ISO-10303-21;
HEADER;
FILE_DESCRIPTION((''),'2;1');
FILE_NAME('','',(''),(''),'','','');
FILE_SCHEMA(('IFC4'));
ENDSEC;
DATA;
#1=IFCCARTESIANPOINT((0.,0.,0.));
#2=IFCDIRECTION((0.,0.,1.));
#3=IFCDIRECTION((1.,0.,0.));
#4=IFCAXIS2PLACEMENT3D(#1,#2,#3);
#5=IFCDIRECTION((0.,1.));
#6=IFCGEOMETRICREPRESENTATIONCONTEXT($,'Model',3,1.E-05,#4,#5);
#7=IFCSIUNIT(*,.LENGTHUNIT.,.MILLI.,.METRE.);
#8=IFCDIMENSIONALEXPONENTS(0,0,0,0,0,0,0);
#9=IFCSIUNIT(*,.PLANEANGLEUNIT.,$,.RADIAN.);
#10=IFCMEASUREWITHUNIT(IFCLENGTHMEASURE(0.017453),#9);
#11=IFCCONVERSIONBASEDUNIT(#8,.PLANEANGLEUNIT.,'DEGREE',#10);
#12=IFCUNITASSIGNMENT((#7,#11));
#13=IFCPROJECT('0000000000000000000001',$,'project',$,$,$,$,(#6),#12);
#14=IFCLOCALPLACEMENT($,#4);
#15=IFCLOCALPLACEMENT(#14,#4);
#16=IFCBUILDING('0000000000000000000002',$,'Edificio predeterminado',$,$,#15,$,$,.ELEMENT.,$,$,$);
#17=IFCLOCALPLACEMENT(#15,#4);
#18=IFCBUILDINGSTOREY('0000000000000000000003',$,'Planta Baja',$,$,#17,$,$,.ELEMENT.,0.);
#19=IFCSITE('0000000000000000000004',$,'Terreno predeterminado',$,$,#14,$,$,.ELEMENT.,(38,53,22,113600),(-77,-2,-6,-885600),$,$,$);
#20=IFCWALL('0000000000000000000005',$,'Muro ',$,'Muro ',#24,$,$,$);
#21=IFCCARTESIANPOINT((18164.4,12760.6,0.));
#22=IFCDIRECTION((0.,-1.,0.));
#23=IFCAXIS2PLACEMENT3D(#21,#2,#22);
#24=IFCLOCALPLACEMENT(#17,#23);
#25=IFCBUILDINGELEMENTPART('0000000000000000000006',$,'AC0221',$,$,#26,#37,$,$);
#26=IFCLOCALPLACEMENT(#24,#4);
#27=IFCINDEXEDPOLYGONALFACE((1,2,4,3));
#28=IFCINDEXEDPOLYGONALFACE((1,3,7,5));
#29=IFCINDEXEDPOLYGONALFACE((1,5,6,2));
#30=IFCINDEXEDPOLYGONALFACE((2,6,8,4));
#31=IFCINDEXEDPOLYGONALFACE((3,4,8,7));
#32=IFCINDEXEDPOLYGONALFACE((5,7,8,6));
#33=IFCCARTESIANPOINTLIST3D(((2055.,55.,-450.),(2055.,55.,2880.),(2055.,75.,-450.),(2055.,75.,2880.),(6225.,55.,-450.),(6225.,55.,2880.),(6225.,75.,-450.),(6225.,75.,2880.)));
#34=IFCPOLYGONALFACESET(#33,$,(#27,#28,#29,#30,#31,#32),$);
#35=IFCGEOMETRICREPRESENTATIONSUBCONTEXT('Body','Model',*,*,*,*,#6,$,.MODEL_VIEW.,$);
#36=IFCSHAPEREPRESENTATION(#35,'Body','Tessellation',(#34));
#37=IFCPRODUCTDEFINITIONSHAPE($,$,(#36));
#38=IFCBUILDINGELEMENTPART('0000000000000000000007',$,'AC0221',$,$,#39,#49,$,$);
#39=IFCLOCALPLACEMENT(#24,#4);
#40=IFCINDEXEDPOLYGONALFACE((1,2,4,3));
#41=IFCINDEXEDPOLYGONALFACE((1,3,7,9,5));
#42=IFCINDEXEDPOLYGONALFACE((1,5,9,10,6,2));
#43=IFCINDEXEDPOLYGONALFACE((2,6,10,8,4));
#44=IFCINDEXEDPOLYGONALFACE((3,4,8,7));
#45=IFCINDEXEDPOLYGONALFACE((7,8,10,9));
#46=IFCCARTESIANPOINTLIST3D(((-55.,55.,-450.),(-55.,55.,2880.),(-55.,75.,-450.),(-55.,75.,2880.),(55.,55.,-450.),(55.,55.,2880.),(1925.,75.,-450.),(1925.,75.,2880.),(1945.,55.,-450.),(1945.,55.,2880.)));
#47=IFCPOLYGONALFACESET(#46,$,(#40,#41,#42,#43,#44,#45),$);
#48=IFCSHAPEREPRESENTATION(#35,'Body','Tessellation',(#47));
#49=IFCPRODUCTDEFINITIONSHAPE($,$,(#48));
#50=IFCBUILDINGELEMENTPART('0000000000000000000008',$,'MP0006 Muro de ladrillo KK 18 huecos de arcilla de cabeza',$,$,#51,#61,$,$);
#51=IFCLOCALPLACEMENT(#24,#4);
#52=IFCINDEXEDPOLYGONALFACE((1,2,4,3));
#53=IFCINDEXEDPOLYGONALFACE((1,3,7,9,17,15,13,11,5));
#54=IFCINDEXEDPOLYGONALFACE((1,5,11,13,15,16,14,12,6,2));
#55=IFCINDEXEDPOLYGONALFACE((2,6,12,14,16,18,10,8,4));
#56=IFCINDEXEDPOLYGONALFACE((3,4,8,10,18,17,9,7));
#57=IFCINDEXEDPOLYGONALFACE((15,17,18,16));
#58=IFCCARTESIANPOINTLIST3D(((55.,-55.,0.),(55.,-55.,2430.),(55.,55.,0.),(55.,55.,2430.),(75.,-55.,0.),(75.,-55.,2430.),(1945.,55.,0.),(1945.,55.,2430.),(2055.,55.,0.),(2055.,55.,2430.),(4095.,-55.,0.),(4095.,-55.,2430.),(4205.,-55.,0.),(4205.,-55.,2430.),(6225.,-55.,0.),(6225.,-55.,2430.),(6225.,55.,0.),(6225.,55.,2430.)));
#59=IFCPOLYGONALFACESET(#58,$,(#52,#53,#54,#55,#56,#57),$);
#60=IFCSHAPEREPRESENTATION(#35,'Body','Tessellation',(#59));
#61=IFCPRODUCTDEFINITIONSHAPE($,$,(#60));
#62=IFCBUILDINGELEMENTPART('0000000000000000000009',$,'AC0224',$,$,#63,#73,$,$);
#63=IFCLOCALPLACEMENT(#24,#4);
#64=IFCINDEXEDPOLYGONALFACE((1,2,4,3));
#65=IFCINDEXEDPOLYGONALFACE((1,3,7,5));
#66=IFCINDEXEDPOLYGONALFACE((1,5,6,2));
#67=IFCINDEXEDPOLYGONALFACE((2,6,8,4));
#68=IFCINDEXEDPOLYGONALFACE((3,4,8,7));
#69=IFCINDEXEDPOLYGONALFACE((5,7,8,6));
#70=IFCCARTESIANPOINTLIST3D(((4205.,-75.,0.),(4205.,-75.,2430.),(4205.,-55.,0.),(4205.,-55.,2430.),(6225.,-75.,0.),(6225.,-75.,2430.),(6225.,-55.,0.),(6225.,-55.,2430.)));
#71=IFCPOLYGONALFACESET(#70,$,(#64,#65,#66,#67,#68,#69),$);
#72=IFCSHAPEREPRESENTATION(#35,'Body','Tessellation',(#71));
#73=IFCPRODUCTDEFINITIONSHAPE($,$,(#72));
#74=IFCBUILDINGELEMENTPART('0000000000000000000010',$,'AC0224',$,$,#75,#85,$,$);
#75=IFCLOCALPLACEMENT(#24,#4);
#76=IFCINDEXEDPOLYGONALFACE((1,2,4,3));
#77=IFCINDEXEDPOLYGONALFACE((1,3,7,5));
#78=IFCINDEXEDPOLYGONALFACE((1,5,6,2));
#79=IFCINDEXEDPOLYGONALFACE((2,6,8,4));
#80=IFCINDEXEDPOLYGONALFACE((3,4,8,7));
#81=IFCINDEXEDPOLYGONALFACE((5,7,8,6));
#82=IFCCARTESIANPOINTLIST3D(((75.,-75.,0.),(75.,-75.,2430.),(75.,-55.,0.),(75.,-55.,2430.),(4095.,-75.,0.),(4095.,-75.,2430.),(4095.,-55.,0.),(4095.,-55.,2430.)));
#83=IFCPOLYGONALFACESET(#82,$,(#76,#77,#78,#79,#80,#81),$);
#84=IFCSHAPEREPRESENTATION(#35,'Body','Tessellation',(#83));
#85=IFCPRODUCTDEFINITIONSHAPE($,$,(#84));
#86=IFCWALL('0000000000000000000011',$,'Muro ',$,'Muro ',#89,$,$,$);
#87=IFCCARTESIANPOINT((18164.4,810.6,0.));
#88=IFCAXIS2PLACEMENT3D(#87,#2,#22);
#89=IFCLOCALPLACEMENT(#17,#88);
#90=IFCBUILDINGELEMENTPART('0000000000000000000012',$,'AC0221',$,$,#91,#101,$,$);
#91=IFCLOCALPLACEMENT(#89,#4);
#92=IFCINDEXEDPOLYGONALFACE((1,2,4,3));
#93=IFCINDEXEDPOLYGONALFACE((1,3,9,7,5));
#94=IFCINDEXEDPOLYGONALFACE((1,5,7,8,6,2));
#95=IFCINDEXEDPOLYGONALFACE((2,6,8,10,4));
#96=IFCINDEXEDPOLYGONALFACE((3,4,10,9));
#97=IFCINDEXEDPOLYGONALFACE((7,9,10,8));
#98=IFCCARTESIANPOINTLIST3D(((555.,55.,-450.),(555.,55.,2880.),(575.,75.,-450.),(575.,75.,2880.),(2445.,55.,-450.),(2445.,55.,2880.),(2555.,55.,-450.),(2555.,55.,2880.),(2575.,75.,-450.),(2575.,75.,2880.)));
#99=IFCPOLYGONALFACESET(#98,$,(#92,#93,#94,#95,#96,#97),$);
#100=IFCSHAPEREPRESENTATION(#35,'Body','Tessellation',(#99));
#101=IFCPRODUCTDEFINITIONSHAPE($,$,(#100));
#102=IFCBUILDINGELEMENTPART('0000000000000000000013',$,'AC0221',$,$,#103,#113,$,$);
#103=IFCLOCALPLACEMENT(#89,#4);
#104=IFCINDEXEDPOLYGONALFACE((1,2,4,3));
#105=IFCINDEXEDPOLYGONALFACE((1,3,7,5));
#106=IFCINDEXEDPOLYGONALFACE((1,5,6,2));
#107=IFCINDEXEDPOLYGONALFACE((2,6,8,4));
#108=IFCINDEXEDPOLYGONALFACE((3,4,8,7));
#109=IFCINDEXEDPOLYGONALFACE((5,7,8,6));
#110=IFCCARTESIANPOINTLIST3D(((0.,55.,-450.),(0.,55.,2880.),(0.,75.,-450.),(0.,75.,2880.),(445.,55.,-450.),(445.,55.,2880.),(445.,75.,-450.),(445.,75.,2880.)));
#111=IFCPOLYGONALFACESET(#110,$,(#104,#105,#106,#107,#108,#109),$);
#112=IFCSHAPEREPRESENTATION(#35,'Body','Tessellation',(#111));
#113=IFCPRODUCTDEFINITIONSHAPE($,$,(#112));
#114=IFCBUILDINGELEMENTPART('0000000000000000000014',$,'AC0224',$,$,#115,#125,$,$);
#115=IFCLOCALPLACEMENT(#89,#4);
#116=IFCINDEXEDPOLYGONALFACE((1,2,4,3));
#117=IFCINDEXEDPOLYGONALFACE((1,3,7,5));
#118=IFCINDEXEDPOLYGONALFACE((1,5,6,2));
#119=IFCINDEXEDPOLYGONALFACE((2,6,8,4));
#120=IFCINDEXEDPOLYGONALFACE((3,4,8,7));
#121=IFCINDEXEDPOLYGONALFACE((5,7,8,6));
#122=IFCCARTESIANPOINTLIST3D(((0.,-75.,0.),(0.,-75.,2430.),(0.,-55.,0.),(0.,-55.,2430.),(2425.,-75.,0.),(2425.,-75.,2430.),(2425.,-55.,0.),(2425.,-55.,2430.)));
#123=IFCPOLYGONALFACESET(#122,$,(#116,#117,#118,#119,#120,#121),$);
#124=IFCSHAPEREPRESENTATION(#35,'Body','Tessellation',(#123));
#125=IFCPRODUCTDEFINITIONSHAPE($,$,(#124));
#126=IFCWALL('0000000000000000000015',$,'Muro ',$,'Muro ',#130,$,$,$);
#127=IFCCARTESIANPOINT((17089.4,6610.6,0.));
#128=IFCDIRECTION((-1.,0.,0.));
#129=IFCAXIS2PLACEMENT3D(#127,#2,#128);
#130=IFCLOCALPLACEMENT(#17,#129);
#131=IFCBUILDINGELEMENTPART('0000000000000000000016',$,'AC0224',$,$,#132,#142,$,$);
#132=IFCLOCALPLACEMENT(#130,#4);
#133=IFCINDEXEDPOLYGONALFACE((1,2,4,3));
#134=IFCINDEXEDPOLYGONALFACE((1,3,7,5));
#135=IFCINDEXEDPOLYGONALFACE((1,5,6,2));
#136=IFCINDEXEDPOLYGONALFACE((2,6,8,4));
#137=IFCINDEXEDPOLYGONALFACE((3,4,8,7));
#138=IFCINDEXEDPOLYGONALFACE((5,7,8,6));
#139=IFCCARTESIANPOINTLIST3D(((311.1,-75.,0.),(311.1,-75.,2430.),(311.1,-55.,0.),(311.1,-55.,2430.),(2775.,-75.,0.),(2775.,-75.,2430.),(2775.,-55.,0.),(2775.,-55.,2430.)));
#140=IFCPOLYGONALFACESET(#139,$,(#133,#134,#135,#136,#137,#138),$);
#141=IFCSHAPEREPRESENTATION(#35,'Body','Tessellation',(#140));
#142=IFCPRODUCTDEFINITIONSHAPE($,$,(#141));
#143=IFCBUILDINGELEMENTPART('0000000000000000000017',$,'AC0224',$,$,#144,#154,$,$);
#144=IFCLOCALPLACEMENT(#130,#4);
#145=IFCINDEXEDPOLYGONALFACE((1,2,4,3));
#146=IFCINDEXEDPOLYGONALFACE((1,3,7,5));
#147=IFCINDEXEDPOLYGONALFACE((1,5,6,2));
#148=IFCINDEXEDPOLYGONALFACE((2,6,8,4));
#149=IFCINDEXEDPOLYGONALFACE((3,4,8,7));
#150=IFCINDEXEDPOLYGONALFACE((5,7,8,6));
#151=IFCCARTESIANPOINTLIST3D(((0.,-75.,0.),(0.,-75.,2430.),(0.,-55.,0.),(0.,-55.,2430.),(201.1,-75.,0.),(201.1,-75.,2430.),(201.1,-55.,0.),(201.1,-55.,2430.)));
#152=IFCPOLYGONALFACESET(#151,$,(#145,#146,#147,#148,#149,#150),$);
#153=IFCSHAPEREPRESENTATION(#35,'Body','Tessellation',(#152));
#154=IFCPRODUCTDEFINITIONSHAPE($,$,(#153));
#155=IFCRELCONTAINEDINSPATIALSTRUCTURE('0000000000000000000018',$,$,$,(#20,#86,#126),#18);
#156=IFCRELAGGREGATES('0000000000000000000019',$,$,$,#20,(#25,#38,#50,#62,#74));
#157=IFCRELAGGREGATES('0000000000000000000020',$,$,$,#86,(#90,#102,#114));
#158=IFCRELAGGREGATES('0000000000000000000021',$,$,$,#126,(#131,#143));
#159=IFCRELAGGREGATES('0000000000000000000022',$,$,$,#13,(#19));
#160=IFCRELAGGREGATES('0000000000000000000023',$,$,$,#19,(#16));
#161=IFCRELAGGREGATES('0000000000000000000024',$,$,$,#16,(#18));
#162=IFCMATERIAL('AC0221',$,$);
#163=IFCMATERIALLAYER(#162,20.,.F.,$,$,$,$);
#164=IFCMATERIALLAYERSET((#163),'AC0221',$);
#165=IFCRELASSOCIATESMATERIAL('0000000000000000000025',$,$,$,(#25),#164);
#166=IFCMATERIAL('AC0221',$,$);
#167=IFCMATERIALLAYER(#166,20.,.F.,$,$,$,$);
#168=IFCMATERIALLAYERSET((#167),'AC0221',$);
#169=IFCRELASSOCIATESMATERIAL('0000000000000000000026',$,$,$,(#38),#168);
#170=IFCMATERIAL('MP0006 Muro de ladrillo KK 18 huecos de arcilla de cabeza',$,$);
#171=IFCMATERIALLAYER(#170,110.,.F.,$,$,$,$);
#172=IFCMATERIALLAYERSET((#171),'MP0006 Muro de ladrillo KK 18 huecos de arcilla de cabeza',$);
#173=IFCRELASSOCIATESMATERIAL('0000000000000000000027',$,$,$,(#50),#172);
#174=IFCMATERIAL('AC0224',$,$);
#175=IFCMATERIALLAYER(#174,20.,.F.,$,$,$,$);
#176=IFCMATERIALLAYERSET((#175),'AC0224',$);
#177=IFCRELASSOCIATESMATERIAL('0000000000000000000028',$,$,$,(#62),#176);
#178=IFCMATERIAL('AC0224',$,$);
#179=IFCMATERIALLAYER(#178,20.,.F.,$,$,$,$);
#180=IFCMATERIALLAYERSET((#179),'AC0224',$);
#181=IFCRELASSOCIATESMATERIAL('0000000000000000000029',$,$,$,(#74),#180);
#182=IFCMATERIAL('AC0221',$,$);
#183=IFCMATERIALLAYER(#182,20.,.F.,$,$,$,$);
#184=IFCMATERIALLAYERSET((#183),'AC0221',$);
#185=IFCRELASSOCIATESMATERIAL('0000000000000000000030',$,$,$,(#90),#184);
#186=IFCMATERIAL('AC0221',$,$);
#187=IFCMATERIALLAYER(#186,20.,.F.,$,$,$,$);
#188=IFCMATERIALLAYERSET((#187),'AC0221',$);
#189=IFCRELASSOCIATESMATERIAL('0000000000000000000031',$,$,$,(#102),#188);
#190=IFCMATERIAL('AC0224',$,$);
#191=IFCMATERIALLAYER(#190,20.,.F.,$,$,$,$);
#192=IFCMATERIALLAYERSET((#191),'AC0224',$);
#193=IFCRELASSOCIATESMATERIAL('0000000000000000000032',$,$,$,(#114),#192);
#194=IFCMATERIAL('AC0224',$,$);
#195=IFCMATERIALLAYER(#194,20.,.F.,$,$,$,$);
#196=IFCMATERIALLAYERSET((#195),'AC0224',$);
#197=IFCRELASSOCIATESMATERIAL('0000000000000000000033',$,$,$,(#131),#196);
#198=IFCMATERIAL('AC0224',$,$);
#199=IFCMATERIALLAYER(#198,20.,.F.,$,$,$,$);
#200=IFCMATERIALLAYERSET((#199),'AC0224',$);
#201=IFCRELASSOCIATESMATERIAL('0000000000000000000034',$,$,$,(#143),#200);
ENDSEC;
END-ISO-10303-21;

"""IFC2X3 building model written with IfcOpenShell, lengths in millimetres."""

from ifc_helpers import new_model, entity, si_unit, converted_unit, direction, frame, origin_with_axes, place, context, subcontext, project, spatial, polyline, outline, extrude, material, layer, layer_set, layer_usage, element, aggregate, save


model = new_model("IFC2X3")

# Units and contexts
model_context = context("Model", 3, precision=1e-05, world=origin_with_axes(), true_north=direction((0.0, 1.0)))
body_context = subcontext(model_context, "Body", "Model", "MODEL_VIEW")
ifc_project = project(units=[si_unit("LENGTHUNIT", "METRE", prefix="MILLI"), converted_unit("PLANEANGLEUNIT", "DEGREE", entity("IfcLengthMeasure", 0.017453), si_unit("PLANEANGLEUNIT", "RADIAN"), dimensions=[0, 0, 0, 0, 0, 0, 0])], contexts=[model_context])

# Site, building, storey
site_placement = place(None, origin_with_axes())
site = spatial("IfcSite", under=ifc_project, at=site_placement, Name="Terreno predeterminado", CompositionType="ELEMENT", RefLatitude=(38, 53, 22, 113600), RefLongitude=(-77, -2, -6, -885600))
building_placement = place(site_placement, origin_with_axes())
building = spatial("IfcBuilding", under=site, at=building_placement, Name="Edificio predeterminado", CompositionType="ELEMENT")
storey_placement = place(building_placement, origin_with_axes())
storey = spatial("IfcBuildingStorey", under=building, at=storey_placement, Name="Planta Baja", CompositionType="ELEMENT", Elevation=0.0)

# Walls, building element parts
wall_1_placement = place(storey_placement, frame((18164.4, 12760.6, 0.0), z_axis=(0.0, 0.0, 1.0), x_axis=(0.0, -1.0, 0.0)))
wall_1 = element("IfcWall", 1, at=wall_1_placement, inside=storey, Name="Muro ", ObjectType="Muro ")
ifc_material_1 = material(Name="AC0221")
ifc_layer_1 = layer(ifc_material_1, 20.0, ventilated=False)
ifc_layer_set_1 = layer_set([ifc_layer_1], Name="AC0221")
ifc_layer_usage_1 = layer_usage(ifc_layer_set_1, "AXIS2", "NEGATIVE", -75.0)
building_element_part_1_placement = place(wall_1_placement, origin_with_axes())
building_element_part_1 = element("IfcBuildingElementPart", 2, at=building_element_part_1_placement, material=ifc_layer_usage_1, Name="AC0221", context=body_context, shape_type="SweptSolid", body=[
    extrude(outline(polyline([(6225.0, 75.0), (6225.0, 55.0), (2055.0, 55.0), (2055.0, 75.0), (6225.0, 75.0)])), frame((0.0, 0.0, -450.0), z_axis=(0.0, 0.0, 1.0), x_axis=(1.0, 0.0, 0.0)), (0.0, 0.0, 1.0), 3330.0),
])
ifc_material_2 = material(Name="AC0221")
ifc_layer_2 = layer(ifc_material_2, 20.0, ventilated=False)
ifc_layer_set_2 = layer_set([ifc_layer_2], Name="AC0221")
ifc_layer_usage_2 = layer_usage(ifc_layer_set_2, "AXIS2", "NEGATIVE", -75.0)
building_element_part_2_placement = place(wall_1_placement, origin_with_axes())
building_element_part_2 = element("IfcBuildingElementPart", 3, at=building_element_part_2_placement, material=ifc_layer_usage_2, Name="AC0221", context=body_context, shape_type="SweptSolid", body=[
    extrude(outline(polyline([(1925.0, 75.0), (1945.0, 55.0), (55.0, 55.0), (-55.0, 55.0), (-55.0, 75.0), (1925.0, 75.0)])), frame((0.0, 0.0, -450.0), z_axis=(0.0, 0.0, 1.0), x_axis=(1.0, 0.0, 0.0)), (0.0, 0.0, 1.0), 3330.0),
])
ifc_material_3 = material(Name="MP0006 Muro de ladrillo KK 18 huecos de arcilla de cabeza")
ifc_layer_3 = layer(ifc_material_3, 110.0, ventilated=False)
ifc_layer_set_3 = layer_set([ifc_layer_3], Name="MP0006 Muro de ladrillo KK 18 huecos de arcilla de cabeza")
ifc_layer_usage_3 = layer_usage(ifc_layer_set_3, "AXIS2", "NEGATIVE", -55.0)
building_element_part_3_placement = place(wall_1_placement, origin_with_axes())
building_element_part_3 = element("IfcBuildingElementPart", 4, at=building_element_part_3_placement, material=ifc_layer_usage_3, Name="MP0006 Muro de ladrillo KK 18 huecos de arcilla de cabeza", context=body_context, shape_type="SweptSolid", body=[
    extrude(outline(polyline([(6225.0, 55.0), (6225.0, -55.0), (4205.0, -55.0), (4095.0, -55.0), (75.0, -55.0), (55.0, -55.0), (55.0, 55.0), (1945.0, 55.0), (2055.0, 55.0), (6225.0, 55.0)])), origin_with_axes(), (0.0, 0.0, 1.0), 2430.0),
])
ifc_material_4 = material(Name="AC0224")
ifc_layer_4 = layer(ifc_material_4, 20.0, ventilated=False)
ifc_layer_set_4 = layer_set([ifc_layer_4], Name="AC0224")
ifc_layer_usage_4 = layer_usage(ifc_layer_set_4, "AXIS2", "NEGATIVE", 55.0)
building_element_part_4_placement = place(wall_1_placement, origin_with_axes())
building_element_part_4 = element("IfcBuildingElementPart", 5, at=building_element_part_4_placement, material=ifc_layer_usage_4, Name="AC0224", context=body_context, shape_type="SweptSolid", body=[
    extrude(outline(polyline([(6225.0, -55.0), (6225.0, -75.0), (4205.0, -75.0), (4205.0, -55.0), (6225.0, -55.0)])), origin_with_axes(), (0.0, 0.0, 1.0), 2430.0),
])
ifc_material_5 = material(Name="AC0224")
ifc_layer_5 = layer(ifc_material_5, 20.0, ventilated=False)
ifc_layer_set_5 = layer_set([ifc_layer_5], Name="AC0224")
ifc_layer_usage_5 = layer_usage(ifc_layer_set_5, "AXIS2", "NEGATIVE", 55.0)
building_element_part_5_placement = place(wall_1_placement, origin_with_axes())
building_element_part_5 = element("IfcBuildingElementPart", 6, at=building_element_part_5_placement, material=ifc_layer_usage_5, Name="AC0224", context=body_context, shape_type="SweptSolid", body=[
    extrude(outline(polyline([(4095.0, -55.0), (4095.0, -75.0), (75.0, -75.0), (75.0, -55.0), (4095.0, -55.0)])), origin_with_axes(), (0.0, 0.0, 1.0), 2430.0),
])
aggregate(wall_1, [building_element_part_1, building_element_part_2, building_element_part_3, building_element_part_4, building_element_part_5])
wall_2_placement = place(storey_placement, frame((18164.4, 810.6, 0.0), z_axis=(0.0, 0.0, 1.0), x_axis=(0.0, -1.0, 0.0)))
wall_2 = element("IfcWall", 7, at=wall_2_placement, inside=storey, Name="Muro ", ObjectType="Muro ")
ifc_material_6 = material(Name="AC0221")
ifc_layer_6 = layer(ifc_material_6, 20.0, ventilated=False)
ifc_layer_set_6 = layer_set([ifc_layer_6], Name="AC0221")
ifc_layer_usage_6 = layer_usage(ifc_layer_set_6, "AXIS2", "NEGATIVE", -75.0)
building_element_part_6_placement = place(wall_2_placement, origin_with_axes())
building_element_part_6 = element("IfcBuildingElementPart", 8, at=building_element_part_6_placement, material=ifc_layer_usage_6, Name="AC0221", context=body_context, shape_type="SweptSolid", body=[
    extrude(outline(polyline([(2575.0, 75.0), (2555.0, 55.0), (2445.0, 55.0), (555.0, 55.0), (575.0, 75.0), (2575.0, 75.0)])), frame((0.0, 0.0, -450.0), z_axis=(0.0, 0.0, 1.0), x_axis=(1.0, 0.0, 0.0)), (0.0, 0.0, 1.0), 3330.0),
])
ifc_material_7 = material(Name="AC0221")
ifc_layer_7 = layer(ifc_material_7, 20.0, ventilated=False)
ifc_layer_set_7 = layer_set([ifc_layer_7], Name="AC0221")
ifc_layer_usage_7 = layer_usage(ifc_layer_set_7, "AXIS2", "NEGATIVE", -75.0)
building_element_part_7_placement = place(wall_2_placement, origin_with_axes())
building_element_part_7 = element("IfcBuildingElementPart", 9, at=building_element_part_7_placement, material=ifc_layer_usage_7, Name="AC0221", context=body_context, shape_type="SweptSolid", body=[
    extrude(outline(polyline([(445.0, 75.0), (445.0, 55.0), (0.0, 55.0), (0.0, 75.0), (445.0, 75.0)])), frame((0.0, 0.0, -450.0), z_axis=(0.0, 0.0, 1.0), x_axis=(1.0, 0.0, 0.0)), (0.0, 0.0, 1.0), 3330.0),
])
ifc_material_8 = material(Name="AC0224")
ifc_layer_8 = layer(ifc_material_8, 20.0, ventilated=False)
ifc_layer_set_8 = layer_set([ifc_layer_8], Name="AC0224")
ifc_layer_usage_8 = layer_usage(ifc_layer_set_8, "AXIS2", "NEGATIVE", 55.0)
building_element_part_8_placement = place(wall_2_placement, origin_with_axes())
building_element_part_8 = element("IfcBuildingElementPart", 10, at=building_element_part_8_placement, material=ifc_layer_usage_8, Name="AC0224", context=body_context, shape_type="SweptSolid", body=[
    extrude(outline(polyline([(2425.0, -55.0), (2425.0, -75.0), (0.0, -75.0), (0.0, -55.0), (2425.0, -55.0)])), origin_with_axes(), (0.0, 0.0, 1.0), 2430.0),
])
aggregate(wall_2, [building_element_part_6, building_element_part_7, building_element_part_8])
wall_3_placement = place(storey_placement, frame((17089.4, 6610.6, 0.0), z_axis=(0.0, 0.0, 1.0), x_axis=(-1.0, 0.0, 0.0)))
wall_3 = element("IfcWall", 11, at=wall_3_placement, inside=storey, Name="Muro ", ObjectType="Muro ")
ifc_material_9 = material(Name="AC0224")
ifc_layer_9 = layer(ifc_material_9, 20.0, ventilated=False)
ifc_layer_set_9 = layer_set([ifc_layer_9], Name="AC0224")
ifc_layer_usage_9 = layer_usage(ifc_layer_set_9, "AXIS2", "NEGATIVE", 55.0)
building_element_part_9_placement = place(wall_3_placement, origin_with_axes())
building_element_part_9 = element("IfcBuildingElementPart", 12, at=building_element_part_9_placement, material=ifc_layer_usage_9, Name="AC0224", context=body_context, shape_type="SweptSolid", body=[
    extrude(outline(polyline([(2775.0, -55.0), (2775.0, -75.0), (311.1, -75.0), (311.1, -55.0), (2775.0, -55.0)])), origin_with_axes(), (0.0, 0.0, 1.0), 2430.0),
])
ifc_material_10 = material(Name="AC0224")
ifc_layer_10 = layer(ifc_material_10, 20.0, ventilated=False)
ifc_layer_set_10 = layer_set([ifc_layer_10], Name="AC0224")
ifc_layer_usage_10 = layer_usage(ifc_layer_set_10, "AXIS2", "NEGATIVE", 55.0)
building_element_part_10_placement = place(wall_3_placement, origin_with_axes())
building_element_part_10 = element("IfcBuildingElementPart", 13, at=building_element_part_10_placement, material=ifc_layer_usage_10, Name="AC0224", context=body_context, shape_type="SweptSolid", body=[
    extrude(outline(polyline([(201.1, -55.0), (201.1, -75.0), (0.0, -75.0), (0.0, -55.0), (201.1, -55.0)])), origin_with_axes(), (0.0, 0.0, 1.0), 2430.0),
])
aggregate(wall_3, [building_element_part_9, building_element_part_10])

save(model, "model.ifc")
